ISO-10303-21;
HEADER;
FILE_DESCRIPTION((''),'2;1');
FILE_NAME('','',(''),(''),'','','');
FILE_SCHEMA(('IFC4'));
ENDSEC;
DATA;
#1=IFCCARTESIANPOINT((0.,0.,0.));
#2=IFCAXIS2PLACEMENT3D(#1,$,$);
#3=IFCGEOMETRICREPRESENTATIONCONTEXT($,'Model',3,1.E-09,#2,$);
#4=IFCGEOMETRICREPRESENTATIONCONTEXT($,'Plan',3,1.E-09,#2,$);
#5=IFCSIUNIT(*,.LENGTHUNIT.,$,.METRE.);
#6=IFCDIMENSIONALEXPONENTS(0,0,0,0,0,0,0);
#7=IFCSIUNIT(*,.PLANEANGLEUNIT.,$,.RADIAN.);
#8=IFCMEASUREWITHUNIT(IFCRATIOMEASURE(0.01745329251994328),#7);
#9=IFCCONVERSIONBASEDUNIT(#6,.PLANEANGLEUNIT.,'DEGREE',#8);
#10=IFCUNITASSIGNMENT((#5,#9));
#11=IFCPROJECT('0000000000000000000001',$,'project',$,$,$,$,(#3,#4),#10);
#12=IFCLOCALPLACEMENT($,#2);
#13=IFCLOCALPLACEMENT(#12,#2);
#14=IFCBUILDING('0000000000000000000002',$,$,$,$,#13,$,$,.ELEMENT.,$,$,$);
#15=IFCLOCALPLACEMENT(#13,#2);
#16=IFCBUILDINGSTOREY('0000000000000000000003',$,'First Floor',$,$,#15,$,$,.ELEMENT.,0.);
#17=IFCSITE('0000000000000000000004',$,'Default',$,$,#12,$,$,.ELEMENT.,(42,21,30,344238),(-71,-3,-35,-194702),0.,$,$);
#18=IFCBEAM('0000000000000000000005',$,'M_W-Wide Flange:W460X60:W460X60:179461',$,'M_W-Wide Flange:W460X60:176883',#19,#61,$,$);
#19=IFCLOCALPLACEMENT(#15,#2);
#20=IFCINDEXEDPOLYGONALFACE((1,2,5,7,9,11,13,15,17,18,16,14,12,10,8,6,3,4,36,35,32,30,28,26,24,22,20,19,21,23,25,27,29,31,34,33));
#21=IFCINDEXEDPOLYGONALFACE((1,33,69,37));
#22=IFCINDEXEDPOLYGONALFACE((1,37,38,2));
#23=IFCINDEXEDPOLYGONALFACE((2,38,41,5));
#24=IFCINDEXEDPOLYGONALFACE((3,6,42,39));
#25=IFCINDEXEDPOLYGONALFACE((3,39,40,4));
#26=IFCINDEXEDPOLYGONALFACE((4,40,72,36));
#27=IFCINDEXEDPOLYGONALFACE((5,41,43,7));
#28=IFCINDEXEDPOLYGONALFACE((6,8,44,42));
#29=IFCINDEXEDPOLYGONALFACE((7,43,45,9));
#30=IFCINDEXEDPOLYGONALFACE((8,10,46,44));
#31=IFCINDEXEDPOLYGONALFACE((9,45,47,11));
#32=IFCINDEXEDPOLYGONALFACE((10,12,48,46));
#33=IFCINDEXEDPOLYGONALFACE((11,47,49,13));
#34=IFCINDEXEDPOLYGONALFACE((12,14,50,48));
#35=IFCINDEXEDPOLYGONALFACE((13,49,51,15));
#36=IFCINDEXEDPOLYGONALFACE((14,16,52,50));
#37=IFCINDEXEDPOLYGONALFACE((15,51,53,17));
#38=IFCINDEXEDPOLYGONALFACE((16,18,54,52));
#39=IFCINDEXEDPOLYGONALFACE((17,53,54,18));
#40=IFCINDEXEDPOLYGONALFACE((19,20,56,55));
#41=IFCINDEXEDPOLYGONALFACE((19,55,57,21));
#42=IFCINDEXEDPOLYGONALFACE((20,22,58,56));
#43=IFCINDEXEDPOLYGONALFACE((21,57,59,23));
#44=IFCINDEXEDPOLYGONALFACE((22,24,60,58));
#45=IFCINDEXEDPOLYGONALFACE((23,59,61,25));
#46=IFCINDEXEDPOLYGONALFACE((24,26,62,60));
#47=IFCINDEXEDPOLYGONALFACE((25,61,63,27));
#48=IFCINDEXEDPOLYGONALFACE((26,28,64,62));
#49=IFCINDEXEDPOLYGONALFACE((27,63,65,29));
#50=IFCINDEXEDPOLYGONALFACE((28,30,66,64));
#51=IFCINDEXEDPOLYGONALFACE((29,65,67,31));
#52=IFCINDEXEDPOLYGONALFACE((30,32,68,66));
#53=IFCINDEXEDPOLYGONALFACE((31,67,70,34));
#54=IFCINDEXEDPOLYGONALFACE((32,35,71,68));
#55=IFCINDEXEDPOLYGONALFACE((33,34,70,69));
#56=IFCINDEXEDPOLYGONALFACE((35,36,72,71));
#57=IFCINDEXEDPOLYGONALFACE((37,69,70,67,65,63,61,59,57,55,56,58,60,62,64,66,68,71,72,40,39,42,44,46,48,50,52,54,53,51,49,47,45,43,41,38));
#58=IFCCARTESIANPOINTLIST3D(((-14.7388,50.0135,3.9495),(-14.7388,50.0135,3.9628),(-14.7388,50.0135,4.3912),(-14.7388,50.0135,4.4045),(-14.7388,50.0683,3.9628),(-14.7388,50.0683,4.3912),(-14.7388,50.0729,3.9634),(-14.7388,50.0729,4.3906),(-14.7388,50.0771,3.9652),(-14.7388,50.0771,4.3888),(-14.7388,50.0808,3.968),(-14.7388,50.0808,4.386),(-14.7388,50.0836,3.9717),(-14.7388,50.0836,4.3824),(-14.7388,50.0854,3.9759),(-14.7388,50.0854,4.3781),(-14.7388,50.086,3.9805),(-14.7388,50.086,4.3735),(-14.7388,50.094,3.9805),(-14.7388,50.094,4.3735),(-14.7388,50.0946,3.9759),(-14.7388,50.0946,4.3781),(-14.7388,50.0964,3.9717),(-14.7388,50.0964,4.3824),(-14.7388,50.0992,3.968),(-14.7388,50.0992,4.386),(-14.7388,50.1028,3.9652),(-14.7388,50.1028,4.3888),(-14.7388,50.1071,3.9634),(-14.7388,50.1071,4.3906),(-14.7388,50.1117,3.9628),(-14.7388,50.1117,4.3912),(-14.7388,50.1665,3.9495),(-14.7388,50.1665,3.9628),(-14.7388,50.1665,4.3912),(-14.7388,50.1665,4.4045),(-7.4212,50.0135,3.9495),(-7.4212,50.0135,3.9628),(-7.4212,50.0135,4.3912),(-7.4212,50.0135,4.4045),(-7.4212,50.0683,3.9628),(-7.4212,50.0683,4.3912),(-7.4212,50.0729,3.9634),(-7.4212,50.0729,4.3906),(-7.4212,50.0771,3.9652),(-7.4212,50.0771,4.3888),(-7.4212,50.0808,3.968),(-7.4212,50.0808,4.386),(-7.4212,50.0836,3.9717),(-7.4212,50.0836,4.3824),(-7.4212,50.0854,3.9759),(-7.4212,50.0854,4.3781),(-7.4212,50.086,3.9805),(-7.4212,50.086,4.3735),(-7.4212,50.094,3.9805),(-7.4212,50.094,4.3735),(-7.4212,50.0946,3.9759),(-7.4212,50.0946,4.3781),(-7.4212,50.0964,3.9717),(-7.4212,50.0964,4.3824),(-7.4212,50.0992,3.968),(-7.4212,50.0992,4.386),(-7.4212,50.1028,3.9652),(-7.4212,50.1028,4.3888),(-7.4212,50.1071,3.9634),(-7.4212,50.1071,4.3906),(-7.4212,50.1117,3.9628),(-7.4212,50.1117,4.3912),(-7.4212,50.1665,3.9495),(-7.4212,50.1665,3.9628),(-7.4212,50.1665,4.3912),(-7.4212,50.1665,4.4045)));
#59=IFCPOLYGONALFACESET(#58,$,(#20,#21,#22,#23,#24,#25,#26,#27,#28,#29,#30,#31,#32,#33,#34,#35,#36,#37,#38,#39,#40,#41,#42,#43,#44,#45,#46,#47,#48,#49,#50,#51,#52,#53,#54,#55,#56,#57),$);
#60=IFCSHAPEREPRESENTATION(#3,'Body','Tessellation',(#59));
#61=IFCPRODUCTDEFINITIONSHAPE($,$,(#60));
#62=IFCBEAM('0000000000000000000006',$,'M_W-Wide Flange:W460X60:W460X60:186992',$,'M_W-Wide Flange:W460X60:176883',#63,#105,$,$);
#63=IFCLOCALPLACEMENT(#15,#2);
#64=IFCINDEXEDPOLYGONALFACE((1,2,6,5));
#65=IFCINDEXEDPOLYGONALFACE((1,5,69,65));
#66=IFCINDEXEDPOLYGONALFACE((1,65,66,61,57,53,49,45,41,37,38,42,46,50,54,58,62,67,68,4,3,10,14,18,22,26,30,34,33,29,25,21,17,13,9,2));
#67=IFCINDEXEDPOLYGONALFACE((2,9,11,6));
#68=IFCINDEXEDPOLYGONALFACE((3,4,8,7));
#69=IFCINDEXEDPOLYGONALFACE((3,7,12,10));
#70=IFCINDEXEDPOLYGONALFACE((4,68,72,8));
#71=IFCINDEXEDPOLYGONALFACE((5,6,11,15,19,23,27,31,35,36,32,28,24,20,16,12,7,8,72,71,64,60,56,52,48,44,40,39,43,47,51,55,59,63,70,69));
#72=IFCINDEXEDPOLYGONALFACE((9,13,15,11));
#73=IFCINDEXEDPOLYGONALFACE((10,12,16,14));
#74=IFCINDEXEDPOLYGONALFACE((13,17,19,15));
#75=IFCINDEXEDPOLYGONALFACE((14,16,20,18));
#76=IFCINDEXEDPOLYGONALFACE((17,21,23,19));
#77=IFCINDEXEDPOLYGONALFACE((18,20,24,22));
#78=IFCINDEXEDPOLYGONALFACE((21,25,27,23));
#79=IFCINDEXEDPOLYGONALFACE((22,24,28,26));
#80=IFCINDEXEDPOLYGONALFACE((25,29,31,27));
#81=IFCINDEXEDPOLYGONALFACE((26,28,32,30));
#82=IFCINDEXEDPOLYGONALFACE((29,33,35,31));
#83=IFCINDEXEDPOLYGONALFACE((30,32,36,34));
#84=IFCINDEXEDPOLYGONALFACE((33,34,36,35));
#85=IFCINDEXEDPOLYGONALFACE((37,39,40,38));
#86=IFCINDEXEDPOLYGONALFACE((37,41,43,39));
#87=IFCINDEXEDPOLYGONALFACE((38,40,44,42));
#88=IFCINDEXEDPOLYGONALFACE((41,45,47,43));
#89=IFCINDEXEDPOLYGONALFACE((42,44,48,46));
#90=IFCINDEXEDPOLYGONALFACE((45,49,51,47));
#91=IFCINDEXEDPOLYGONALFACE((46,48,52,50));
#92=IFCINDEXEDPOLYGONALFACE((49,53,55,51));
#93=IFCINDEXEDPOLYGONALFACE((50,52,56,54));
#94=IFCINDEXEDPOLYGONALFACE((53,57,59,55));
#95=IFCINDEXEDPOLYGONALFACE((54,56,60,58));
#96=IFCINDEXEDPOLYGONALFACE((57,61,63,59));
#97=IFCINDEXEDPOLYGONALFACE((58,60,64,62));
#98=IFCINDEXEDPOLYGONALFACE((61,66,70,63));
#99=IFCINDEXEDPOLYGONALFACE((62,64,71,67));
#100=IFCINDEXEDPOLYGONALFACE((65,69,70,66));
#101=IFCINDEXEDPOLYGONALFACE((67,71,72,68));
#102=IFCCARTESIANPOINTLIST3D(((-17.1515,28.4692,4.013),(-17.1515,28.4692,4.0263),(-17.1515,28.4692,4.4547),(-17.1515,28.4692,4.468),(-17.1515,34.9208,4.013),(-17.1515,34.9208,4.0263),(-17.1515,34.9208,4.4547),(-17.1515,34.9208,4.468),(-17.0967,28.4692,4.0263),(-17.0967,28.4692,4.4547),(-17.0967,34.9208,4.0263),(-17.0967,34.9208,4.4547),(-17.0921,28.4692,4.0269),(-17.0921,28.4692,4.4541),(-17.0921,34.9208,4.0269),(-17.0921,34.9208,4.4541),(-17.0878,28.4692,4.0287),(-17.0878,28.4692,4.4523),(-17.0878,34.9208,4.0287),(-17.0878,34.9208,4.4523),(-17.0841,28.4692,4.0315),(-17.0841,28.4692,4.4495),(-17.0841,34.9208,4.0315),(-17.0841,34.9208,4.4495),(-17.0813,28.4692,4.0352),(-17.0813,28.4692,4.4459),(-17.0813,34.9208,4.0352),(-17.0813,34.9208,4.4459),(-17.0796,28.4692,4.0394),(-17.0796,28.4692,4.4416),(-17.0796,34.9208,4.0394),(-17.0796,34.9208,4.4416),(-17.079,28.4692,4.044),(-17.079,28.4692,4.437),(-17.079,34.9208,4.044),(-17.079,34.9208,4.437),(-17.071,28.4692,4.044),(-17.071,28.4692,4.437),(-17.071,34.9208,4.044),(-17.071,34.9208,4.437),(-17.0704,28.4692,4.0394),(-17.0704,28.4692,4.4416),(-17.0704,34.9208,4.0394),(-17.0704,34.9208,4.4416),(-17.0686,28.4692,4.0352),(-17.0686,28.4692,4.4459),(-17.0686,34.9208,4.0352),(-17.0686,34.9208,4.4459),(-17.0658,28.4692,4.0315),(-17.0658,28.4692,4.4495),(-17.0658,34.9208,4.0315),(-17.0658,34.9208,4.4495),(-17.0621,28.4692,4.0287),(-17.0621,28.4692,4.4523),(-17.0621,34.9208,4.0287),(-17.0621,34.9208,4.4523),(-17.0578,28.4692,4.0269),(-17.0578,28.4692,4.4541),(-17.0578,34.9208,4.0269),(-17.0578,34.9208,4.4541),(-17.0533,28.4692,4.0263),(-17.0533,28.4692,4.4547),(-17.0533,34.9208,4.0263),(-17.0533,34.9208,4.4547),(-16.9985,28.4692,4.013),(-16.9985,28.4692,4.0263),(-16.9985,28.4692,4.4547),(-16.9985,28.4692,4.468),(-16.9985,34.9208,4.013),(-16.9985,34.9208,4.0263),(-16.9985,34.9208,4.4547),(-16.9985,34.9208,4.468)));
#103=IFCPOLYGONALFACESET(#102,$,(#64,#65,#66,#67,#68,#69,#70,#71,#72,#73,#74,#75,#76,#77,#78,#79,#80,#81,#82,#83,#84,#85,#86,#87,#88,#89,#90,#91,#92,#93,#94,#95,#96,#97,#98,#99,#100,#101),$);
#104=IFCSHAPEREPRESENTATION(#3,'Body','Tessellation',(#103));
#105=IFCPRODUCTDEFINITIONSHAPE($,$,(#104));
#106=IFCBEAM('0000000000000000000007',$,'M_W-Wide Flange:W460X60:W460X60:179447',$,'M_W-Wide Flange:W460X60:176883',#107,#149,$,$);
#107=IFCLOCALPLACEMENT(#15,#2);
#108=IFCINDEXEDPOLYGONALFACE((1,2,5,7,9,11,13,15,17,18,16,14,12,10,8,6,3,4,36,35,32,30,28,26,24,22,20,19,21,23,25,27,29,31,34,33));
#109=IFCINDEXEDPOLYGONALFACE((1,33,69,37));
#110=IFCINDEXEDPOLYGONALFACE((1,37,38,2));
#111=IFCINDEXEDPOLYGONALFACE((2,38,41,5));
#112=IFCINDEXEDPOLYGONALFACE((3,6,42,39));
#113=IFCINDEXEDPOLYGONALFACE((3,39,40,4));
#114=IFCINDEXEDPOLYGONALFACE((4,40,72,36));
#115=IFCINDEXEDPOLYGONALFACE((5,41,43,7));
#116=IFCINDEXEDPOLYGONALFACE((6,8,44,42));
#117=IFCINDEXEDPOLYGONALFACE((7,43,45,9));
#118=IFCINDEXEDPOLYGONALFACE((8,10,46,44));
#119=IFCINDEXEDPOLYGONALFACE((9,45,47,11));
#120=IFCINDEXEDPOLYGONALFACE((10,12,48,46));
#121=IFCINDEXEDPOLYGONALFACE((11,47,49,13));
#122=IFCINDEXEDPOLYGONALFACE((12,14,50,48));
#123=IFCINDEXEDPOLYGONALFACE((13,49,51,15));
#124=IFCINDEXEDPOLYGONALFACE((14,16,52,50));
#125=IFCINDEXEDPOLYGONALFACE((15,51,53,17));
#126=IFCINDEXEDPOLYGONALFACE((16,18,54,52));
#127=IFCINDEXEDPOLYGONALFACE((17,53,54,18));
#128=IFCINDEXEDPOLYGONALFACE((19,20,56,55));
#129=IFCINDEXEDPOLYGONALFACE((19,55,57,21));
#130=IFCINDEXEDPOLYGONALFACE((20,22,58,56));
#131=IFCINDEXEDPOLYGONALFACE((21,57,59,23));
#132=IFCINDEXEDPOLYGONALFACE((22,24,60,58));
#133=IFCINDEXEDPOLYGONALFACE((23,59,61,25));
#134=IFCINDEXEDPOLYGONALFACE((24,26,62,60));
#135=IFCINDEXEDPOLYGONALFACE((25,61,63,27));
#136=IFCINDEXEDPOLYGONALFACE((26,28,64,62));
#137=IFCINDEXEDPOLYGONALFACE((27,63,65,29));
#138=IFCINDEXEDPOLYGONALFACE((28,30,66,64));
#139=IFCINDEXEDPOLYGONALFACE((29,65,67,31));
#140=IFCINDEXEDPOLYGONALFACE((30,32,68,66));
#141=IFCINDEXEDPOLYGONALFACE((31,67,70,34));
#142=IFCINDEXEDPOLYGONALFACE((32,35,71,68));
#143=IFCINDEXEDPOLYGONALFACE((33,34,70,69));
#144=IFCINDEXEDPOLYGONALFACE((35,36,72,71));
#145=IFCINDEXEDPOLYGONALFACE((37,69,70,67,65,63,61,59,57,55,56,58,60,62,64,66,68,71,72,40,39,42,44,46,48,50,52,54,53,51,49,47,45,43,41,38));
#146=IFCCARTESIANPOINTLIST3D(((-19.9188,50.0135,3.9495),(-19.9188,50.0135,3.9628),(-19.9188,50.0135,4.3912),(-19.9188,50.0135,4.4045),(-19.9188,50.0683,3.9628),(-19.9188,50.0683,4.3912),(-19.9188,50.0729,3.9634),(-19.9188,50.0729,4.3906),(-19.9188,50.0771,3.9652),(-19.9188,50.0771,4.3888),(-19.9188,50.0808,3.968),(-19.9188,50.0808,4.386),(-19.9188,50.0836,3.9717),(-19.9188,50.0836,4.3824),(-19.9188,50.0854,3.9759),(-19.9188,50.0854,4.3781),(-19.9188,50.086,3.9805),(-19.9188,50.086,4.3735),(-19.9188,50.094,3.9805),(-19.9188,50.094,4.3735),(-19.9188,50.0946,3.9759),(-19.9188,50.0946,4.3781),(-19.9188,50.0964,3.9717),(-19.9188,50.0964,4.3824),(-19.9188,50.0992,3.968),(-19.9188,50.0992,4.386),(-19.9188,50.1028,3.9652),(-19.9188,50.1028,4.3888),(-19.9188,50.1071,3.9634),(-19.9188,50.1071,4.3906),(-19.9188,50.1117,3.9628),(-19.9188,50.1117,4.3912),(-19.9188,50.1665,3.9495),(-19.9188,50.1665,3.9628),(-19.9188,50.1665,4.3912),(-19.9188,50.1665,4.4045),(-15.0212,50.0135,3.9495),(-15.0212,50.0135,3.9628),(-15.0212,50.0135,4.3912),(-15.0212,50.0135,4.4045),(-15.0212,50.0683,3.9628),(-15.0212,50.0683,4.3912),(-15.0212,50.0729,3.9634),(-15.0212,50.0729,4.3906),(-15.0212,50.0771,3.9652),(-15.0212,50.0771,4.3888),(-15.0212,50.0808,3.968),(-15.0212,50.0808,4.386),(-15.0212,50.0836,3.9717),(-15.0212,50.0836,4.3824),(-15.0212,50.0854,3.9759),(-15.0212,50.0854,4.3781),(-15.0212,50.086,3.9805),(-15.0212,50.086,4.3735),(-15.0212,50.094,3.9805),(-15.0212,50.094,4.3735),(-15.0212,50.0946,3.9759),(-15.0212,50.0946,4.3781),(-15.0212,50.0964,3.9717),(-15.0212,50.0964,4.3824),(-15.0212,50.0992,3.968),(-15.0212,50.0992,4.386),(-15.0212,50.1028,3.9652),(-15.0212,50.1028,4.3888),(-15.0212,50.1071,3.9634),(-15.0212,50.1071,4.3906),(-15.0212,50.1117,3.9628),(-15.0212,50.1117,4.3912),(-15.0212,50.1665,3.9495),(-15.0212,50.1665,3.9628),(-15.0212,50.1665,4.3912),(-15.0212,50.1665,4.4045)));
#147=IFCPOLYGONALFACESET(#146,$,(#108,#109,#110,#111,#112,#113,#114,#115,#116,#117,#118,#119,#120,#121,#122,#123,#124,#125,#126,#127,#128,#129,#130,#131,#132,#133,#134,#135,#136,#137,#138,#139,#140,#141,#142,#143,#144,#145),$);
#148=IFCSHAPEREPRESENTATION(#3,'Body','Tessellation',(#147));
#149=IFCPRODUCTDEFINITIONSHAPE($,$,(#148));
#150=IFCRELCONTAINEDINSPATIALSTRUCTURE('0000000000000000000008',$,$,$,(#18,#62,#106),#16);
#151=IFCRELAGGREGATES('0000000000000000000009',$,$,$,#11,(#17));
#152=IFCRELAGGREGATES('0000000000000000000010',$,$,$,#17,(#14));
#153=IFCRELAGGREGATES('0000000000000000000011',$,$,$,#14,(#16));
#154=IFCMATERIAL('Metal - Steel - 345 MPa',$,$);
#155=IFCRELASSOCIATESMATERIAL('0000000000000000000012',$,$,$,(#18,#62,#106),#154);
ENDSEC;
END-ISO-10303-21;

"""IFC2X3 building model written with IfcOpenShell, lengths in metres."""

from ifc_helpers import new_model, entity, si_unit, converted_unit, frame, frame_2d, origin, place, context, project, spatial, polyline, circle_curve, parameter, trimmed, segment, composite_curve, outline, extrude, material, element, save


model = new_model("IFC2X3")

# Units and contexts
model_context = context("Model", 3, precision=1e-09, world=origin())
plan_context = context("Plan", 3, precision=1e-09, world=origin())
ifc_project = project(units=[si_unit("LENGTHUNIT", "METRE"), converted_unit("PLANEANGLEUNIT", "DEGREE", entity("IfcRatioMeasure", 0.01745329251994328), si_unit("PLANEANGLEUNIT", "RADIAN"), dimensions=[0, 0, 0, 0, 0, 0, 0])], contexts=[model_context, plan_context])

# Site, building, storey
site_placement = place(None, origin())
site = spatial("IfcSite", under=ifc_project, at=site_placement, Name="Default", CompositionType="ELEMENT", RefLatitude=(42, 21, 30, 344238), RefLongitude=(-71, -3, -35, -194702), RefElevation=0.0)
building_placement = place(site_placement, origin())
building = spatial("IfcBuilding", under=site, at=building_placement, CompositionType="ELEMENT")
storey_placement = place(building_placement, origin())
storey = spatial("IfcBuildingStorey", under=building, at=storey_placement, Name="First Floor", CompositionType="ELEMENT", Elevation=0.0)

# Shared definitions
ifc_material = material(Name="Metal - Steel - 345 MPa")

# Beams
beam_1_placement = place(storey_placement, frame((-14.8818, 50.09, 4.4045), z_axis=(0.0, 0.0, 1.0), x_axis=(0.0, -1.0, 0.0)))
element("IfcBeam", 1, at=beam_1_placement, inside=storey, material=ifc_material, Name="M_W-Wide Flange:W460X60:W460X60:179461", ObjectType="M_W-Wide Flange:W460X60:176883", context=model_context, shape_type="SweptSolid", body=[
    extrude(outline(composite_curve([segment(polyline([(-0.0765, -0.2142), (-0.0765, -0.2275)]), True, "CONTINUOUS"), segment(polyline([(-0.0765, -0.2275), (0.0765, -0.2275)]), True, "CONTINUOUS"), segment(polyline([(0.0765, -0.2275), (0.0765, -0.2142)]), True, "CONTINUOUS"), segment(polyline([(0.0765, -0.2142), (0.0217, -0.2142)]), True, "CONTINUOUS"), segment(trimmed(circle_curve(frame_2d((0.0217, -0.1965), x_axis=(0.0, -1.0)), 0.0177), [parameter(270.0)], [parameter(360.0)], True, "PARAMETER"), False, "CONTINUOUS"), segment(polyline([(0.004, -0.1965), (0.004, 0.1965)]), True, "CONTINUOUS"), segment(trimmed(circle_curve(frame_2d((0.0217, 0.1965), x_axis=(-1.0, 0.0)), 0.0177), [parameter(270.0)], [parameter(360.0)], True, "PARAMETER"), False, "CONTINUOUS"), segment(polyline([(0.0217, 0.2142), (0.0765, 0.2142)]), True, "CONTINUOUS"), segment(polyline([(0.0765, 0.2142), (0.0765, 0.2275)]), True, "CONTINUOUS"), segment(polyline([(0.0765, 0.2275), (-0.0765, 0.2275)]), True, "CONTINUOUS"), segment(polyline([(-0.0765, 0.2275), (-0.0765, 0.2142)]), True, "CONTINUOUS"), segment(polyline([(-0.0765, 0.2142), (-0.0217, 0.2142)]), True, "CONTINUOUS"), segment(trimmed(circle_curve(frame_2d((-0.0217, 0.1965), x_axis=(0.0, 1.0)), 0.0177), [parameter(270.0)], [parameter(360.0)], True, "PARAMETER"), False, "CONTINUOUS"), segment(polyline([(-0.004, 0.1965), (-0.004, -0.1965)]), True, "CONTINUOUS"), segment(trimmed(circle_curve(frame_2d((-0.0217, -0.1965), x_axis=(1.0, 0.0)), 0.0177), [parameter(270.0)], [parameter(0.0)], True, "PARAMETER"), False, "CONTINUOUS"), segment(polyline([(-0.0217, -0.2142), (-0.0765, -0.2142)]), True, "CONTINUOUS")], self_intersect=False)), frame((0.0, 0.143, -0.2275), z_axis=(0.0, -1.0, 0.0), x_axis=(1.0, 0.0, 0.0)), (0.0, 0.0, -1.0), 7.3176),
])
beam_2_placement = place(storey_placement, frame((-17.075, 28.528, 4.468)))
element("IfcBeam", 2, at=beam_2_placement, inside=storey, material=ifc_material, Name="M_W-Wide Flange:W460X60:W460X60:186992", ObjectType="M_W-Wide Flange:W460X60:176883", context=model_context, shape_type="SweptSolid", body=[
    extrude(outline(composite_curve([segment(polyline([(-0.0765, -0.2142), (-0.0765, -0.2275)]), True, "CONTINUOUS"), segment(polyline([(-0.0765, -0.2275), (0.0765, -0.2275)]), True, "CONTINUOUS"), segment(polyline([(0.0765, -0.2275), (0.0765, -0.2142)]), True, "CONTINUOUS"), segment(polyline([(0.0765, -0.2142), (0.0217, -0.2142)]), True, "CONTINUOUS"), segment(trimmed(circle_curve(frame_2d((0.0217, -0.1965), x_axis=(1.0, 0.0)), 0.0177), [parameter(180.0)], [parameter(270.0)], True, "PARAMETER"), False, "CONTINUOUS"), segment(polyline([(0.004, -0.1965), (0.004, 0.1965)]), True, "CONTINUOUS"), segment(trimmed(circle_curve(frame_2d((0.0217, 0.1965), x_axis=(1.0, 0.0)), 0.0177), [parameter(90.0)], [parameter(180.0)], True, "PARAMETER"), False, "CONTINUOUS"), segment(polyline([(0.0217, 0.2142), (0.0765, 0.2142)]), True, "CONTINUOUS"), segment(polyline([(0.0765, 0.2142), (0.0765, 0.2275)]), True, "CONTINUOUS"), segment(polyline([(0.0765, 0.2275), (-0.0765, 0.2275)]), True, "CONTINUOUS"), segment(polyline([(-0.0765, 0.2275), (-0.0765, 0.2142)]), True, "CONTINUOUS"), segment(polyline([(-0.0765, 0.2142), (-0.0217, 0.2142)]), True, "CONTINUOUS"), segment(trimmed(circle_curve(frame_2d((-0.0217, 0.1965), x_axis=(1.0, 0.0)), 0.0177), [parameter(360.0)], [parameter(90.0)], True, "PARAMETER"), False, "CONTINUOUS"), segment(polyline([(-0.004, 0.1965), (-0.004, -0.1965)]), True, "CONTINUOUS"), segment(trimmed(circle_curve(frame_2d((-0.0217, -0.1965), x_axis=(1.0, 0.0)), 0.0177), [parameter(270.0)], [parameter(0.0)], True, "PARAMETER"), False, "CONTINUOUS"), segment(polyline([(-0.0217, -0.2142), (-0.0765, -0.2142)]), True, "CONTINUOUS")], self_intersect=False)), frame((0.0, -0.0588, -0.2275), z_axis=(0.0, -1.0, 0.0), x_axis=(1.0, 0.0, 0.0)), (0.0, 0.0, -1.0), 6.4516),
])
beam_3_placement = place(storey_placement, frame((-20.0626, 50.09, 4.4045), z_axis=(0.0, 0.0, 1.0), x_axis=(0.0, -1.0, 0.0)))
element("IfcBeam", 3, at=beam_3_placement, inside=storey, material=ifc_material, Name="M_W-Wide Flange:W460X60:W460X60:179447", ObjectType="M_W-Wide Flange:W460X60:176883", context=model_context, shape_type="SweptSolid", body=[
    extrude(outline(composite_curve([segment(polyline([(-0.0765, -0.2142), (-0.0765, -0.2275)]), True, "CONTINUOUS"), segment(polyline([(-0.0765, -0.2275), (0.0765, -0.2275)]), True, "CONTINUOUS"), segment(polyline([(0.0765, -0.2275), (0.0765, -0.2142)]), True, "CONTINUOUS"), segment(polyline([(0.0765, -0.2142), (0.0217, -0.2142)]), True, "CONTINUOUS"), segment(trimmed(circle_curve(frame_2d((0.0217, -0.1965), x_axis=(0.0, -1.0)), 0.0177), [parameter(270.0)], [parameter(360.0)], True, "PARAMETER"), False, "CONTINUOUS"), segment(polyline([(0.004, -0.1965), (0.004, 0.1965)]), True, "CONTINUOUS"), segment(trimmed(circle_curve(frame_2d((0.0217, 0.1965), x_axis=(-1.0, 0.0)), 0.0177), [parameter(270.0)], [parameter(360.0)], True, "PARAMETER"), False, "CONTINUOUS"), segment(polyline([(0.0217, 0.2142), (0.0765, 0.2142)]), True, "CONTINUOUS"), segment(polyline([(0.0765, 0.2142), (0.0765, 0.2275)]), True, "CONTINUOUS"), segment(polyline([(0.0765, 0.2275), (-0.0765, 0.2275)]), True, "CONTINUOUS"), segment(polyline([(-0.0765, 0.2275), (-0.0765, 0.2142)]), True, "CONTINUOUS"), segment(polyline([(-0.0765, 0.2142), (-0.0217, 0.2142)]), True, "CONTINUOUS"), segment(trimmed(circle_curve(frame_2d((-0.0217, 0.1965), x_axis=(0.0, 1.0)), 0.0177), [parameter(270.0)], [parameter(360.0)], True, "PARAMETER"), False, "CONTINUOUS"), segment(polyline([(-0.004, 0.1965), (-0.004, -0.1965)]), True, "CONTINUOUS"), segment(trimmed(circle_curve(frame_2d((-0.0217, -0.1965), x_axis=(1.0, 0.0)), 0.0177), [parameter(270.0)], [parameter(0.0)], True, "PARAMETER"), False, "CONTINUOUS"), segment(polyline([(-0.0217, -0.2142), (-0.0765, -0.2142)]), True, "CONTINUOUS")], self_intersect=False)), frame((0.0, 0.1438, -0.2275), z_axis=(0.0, -1.0, 0.0), x_axis=(1.0, 0.0, 0.0)), (0.0, 0.0, -1.0), 4.8976),
])

save(model, "model.ifc")
